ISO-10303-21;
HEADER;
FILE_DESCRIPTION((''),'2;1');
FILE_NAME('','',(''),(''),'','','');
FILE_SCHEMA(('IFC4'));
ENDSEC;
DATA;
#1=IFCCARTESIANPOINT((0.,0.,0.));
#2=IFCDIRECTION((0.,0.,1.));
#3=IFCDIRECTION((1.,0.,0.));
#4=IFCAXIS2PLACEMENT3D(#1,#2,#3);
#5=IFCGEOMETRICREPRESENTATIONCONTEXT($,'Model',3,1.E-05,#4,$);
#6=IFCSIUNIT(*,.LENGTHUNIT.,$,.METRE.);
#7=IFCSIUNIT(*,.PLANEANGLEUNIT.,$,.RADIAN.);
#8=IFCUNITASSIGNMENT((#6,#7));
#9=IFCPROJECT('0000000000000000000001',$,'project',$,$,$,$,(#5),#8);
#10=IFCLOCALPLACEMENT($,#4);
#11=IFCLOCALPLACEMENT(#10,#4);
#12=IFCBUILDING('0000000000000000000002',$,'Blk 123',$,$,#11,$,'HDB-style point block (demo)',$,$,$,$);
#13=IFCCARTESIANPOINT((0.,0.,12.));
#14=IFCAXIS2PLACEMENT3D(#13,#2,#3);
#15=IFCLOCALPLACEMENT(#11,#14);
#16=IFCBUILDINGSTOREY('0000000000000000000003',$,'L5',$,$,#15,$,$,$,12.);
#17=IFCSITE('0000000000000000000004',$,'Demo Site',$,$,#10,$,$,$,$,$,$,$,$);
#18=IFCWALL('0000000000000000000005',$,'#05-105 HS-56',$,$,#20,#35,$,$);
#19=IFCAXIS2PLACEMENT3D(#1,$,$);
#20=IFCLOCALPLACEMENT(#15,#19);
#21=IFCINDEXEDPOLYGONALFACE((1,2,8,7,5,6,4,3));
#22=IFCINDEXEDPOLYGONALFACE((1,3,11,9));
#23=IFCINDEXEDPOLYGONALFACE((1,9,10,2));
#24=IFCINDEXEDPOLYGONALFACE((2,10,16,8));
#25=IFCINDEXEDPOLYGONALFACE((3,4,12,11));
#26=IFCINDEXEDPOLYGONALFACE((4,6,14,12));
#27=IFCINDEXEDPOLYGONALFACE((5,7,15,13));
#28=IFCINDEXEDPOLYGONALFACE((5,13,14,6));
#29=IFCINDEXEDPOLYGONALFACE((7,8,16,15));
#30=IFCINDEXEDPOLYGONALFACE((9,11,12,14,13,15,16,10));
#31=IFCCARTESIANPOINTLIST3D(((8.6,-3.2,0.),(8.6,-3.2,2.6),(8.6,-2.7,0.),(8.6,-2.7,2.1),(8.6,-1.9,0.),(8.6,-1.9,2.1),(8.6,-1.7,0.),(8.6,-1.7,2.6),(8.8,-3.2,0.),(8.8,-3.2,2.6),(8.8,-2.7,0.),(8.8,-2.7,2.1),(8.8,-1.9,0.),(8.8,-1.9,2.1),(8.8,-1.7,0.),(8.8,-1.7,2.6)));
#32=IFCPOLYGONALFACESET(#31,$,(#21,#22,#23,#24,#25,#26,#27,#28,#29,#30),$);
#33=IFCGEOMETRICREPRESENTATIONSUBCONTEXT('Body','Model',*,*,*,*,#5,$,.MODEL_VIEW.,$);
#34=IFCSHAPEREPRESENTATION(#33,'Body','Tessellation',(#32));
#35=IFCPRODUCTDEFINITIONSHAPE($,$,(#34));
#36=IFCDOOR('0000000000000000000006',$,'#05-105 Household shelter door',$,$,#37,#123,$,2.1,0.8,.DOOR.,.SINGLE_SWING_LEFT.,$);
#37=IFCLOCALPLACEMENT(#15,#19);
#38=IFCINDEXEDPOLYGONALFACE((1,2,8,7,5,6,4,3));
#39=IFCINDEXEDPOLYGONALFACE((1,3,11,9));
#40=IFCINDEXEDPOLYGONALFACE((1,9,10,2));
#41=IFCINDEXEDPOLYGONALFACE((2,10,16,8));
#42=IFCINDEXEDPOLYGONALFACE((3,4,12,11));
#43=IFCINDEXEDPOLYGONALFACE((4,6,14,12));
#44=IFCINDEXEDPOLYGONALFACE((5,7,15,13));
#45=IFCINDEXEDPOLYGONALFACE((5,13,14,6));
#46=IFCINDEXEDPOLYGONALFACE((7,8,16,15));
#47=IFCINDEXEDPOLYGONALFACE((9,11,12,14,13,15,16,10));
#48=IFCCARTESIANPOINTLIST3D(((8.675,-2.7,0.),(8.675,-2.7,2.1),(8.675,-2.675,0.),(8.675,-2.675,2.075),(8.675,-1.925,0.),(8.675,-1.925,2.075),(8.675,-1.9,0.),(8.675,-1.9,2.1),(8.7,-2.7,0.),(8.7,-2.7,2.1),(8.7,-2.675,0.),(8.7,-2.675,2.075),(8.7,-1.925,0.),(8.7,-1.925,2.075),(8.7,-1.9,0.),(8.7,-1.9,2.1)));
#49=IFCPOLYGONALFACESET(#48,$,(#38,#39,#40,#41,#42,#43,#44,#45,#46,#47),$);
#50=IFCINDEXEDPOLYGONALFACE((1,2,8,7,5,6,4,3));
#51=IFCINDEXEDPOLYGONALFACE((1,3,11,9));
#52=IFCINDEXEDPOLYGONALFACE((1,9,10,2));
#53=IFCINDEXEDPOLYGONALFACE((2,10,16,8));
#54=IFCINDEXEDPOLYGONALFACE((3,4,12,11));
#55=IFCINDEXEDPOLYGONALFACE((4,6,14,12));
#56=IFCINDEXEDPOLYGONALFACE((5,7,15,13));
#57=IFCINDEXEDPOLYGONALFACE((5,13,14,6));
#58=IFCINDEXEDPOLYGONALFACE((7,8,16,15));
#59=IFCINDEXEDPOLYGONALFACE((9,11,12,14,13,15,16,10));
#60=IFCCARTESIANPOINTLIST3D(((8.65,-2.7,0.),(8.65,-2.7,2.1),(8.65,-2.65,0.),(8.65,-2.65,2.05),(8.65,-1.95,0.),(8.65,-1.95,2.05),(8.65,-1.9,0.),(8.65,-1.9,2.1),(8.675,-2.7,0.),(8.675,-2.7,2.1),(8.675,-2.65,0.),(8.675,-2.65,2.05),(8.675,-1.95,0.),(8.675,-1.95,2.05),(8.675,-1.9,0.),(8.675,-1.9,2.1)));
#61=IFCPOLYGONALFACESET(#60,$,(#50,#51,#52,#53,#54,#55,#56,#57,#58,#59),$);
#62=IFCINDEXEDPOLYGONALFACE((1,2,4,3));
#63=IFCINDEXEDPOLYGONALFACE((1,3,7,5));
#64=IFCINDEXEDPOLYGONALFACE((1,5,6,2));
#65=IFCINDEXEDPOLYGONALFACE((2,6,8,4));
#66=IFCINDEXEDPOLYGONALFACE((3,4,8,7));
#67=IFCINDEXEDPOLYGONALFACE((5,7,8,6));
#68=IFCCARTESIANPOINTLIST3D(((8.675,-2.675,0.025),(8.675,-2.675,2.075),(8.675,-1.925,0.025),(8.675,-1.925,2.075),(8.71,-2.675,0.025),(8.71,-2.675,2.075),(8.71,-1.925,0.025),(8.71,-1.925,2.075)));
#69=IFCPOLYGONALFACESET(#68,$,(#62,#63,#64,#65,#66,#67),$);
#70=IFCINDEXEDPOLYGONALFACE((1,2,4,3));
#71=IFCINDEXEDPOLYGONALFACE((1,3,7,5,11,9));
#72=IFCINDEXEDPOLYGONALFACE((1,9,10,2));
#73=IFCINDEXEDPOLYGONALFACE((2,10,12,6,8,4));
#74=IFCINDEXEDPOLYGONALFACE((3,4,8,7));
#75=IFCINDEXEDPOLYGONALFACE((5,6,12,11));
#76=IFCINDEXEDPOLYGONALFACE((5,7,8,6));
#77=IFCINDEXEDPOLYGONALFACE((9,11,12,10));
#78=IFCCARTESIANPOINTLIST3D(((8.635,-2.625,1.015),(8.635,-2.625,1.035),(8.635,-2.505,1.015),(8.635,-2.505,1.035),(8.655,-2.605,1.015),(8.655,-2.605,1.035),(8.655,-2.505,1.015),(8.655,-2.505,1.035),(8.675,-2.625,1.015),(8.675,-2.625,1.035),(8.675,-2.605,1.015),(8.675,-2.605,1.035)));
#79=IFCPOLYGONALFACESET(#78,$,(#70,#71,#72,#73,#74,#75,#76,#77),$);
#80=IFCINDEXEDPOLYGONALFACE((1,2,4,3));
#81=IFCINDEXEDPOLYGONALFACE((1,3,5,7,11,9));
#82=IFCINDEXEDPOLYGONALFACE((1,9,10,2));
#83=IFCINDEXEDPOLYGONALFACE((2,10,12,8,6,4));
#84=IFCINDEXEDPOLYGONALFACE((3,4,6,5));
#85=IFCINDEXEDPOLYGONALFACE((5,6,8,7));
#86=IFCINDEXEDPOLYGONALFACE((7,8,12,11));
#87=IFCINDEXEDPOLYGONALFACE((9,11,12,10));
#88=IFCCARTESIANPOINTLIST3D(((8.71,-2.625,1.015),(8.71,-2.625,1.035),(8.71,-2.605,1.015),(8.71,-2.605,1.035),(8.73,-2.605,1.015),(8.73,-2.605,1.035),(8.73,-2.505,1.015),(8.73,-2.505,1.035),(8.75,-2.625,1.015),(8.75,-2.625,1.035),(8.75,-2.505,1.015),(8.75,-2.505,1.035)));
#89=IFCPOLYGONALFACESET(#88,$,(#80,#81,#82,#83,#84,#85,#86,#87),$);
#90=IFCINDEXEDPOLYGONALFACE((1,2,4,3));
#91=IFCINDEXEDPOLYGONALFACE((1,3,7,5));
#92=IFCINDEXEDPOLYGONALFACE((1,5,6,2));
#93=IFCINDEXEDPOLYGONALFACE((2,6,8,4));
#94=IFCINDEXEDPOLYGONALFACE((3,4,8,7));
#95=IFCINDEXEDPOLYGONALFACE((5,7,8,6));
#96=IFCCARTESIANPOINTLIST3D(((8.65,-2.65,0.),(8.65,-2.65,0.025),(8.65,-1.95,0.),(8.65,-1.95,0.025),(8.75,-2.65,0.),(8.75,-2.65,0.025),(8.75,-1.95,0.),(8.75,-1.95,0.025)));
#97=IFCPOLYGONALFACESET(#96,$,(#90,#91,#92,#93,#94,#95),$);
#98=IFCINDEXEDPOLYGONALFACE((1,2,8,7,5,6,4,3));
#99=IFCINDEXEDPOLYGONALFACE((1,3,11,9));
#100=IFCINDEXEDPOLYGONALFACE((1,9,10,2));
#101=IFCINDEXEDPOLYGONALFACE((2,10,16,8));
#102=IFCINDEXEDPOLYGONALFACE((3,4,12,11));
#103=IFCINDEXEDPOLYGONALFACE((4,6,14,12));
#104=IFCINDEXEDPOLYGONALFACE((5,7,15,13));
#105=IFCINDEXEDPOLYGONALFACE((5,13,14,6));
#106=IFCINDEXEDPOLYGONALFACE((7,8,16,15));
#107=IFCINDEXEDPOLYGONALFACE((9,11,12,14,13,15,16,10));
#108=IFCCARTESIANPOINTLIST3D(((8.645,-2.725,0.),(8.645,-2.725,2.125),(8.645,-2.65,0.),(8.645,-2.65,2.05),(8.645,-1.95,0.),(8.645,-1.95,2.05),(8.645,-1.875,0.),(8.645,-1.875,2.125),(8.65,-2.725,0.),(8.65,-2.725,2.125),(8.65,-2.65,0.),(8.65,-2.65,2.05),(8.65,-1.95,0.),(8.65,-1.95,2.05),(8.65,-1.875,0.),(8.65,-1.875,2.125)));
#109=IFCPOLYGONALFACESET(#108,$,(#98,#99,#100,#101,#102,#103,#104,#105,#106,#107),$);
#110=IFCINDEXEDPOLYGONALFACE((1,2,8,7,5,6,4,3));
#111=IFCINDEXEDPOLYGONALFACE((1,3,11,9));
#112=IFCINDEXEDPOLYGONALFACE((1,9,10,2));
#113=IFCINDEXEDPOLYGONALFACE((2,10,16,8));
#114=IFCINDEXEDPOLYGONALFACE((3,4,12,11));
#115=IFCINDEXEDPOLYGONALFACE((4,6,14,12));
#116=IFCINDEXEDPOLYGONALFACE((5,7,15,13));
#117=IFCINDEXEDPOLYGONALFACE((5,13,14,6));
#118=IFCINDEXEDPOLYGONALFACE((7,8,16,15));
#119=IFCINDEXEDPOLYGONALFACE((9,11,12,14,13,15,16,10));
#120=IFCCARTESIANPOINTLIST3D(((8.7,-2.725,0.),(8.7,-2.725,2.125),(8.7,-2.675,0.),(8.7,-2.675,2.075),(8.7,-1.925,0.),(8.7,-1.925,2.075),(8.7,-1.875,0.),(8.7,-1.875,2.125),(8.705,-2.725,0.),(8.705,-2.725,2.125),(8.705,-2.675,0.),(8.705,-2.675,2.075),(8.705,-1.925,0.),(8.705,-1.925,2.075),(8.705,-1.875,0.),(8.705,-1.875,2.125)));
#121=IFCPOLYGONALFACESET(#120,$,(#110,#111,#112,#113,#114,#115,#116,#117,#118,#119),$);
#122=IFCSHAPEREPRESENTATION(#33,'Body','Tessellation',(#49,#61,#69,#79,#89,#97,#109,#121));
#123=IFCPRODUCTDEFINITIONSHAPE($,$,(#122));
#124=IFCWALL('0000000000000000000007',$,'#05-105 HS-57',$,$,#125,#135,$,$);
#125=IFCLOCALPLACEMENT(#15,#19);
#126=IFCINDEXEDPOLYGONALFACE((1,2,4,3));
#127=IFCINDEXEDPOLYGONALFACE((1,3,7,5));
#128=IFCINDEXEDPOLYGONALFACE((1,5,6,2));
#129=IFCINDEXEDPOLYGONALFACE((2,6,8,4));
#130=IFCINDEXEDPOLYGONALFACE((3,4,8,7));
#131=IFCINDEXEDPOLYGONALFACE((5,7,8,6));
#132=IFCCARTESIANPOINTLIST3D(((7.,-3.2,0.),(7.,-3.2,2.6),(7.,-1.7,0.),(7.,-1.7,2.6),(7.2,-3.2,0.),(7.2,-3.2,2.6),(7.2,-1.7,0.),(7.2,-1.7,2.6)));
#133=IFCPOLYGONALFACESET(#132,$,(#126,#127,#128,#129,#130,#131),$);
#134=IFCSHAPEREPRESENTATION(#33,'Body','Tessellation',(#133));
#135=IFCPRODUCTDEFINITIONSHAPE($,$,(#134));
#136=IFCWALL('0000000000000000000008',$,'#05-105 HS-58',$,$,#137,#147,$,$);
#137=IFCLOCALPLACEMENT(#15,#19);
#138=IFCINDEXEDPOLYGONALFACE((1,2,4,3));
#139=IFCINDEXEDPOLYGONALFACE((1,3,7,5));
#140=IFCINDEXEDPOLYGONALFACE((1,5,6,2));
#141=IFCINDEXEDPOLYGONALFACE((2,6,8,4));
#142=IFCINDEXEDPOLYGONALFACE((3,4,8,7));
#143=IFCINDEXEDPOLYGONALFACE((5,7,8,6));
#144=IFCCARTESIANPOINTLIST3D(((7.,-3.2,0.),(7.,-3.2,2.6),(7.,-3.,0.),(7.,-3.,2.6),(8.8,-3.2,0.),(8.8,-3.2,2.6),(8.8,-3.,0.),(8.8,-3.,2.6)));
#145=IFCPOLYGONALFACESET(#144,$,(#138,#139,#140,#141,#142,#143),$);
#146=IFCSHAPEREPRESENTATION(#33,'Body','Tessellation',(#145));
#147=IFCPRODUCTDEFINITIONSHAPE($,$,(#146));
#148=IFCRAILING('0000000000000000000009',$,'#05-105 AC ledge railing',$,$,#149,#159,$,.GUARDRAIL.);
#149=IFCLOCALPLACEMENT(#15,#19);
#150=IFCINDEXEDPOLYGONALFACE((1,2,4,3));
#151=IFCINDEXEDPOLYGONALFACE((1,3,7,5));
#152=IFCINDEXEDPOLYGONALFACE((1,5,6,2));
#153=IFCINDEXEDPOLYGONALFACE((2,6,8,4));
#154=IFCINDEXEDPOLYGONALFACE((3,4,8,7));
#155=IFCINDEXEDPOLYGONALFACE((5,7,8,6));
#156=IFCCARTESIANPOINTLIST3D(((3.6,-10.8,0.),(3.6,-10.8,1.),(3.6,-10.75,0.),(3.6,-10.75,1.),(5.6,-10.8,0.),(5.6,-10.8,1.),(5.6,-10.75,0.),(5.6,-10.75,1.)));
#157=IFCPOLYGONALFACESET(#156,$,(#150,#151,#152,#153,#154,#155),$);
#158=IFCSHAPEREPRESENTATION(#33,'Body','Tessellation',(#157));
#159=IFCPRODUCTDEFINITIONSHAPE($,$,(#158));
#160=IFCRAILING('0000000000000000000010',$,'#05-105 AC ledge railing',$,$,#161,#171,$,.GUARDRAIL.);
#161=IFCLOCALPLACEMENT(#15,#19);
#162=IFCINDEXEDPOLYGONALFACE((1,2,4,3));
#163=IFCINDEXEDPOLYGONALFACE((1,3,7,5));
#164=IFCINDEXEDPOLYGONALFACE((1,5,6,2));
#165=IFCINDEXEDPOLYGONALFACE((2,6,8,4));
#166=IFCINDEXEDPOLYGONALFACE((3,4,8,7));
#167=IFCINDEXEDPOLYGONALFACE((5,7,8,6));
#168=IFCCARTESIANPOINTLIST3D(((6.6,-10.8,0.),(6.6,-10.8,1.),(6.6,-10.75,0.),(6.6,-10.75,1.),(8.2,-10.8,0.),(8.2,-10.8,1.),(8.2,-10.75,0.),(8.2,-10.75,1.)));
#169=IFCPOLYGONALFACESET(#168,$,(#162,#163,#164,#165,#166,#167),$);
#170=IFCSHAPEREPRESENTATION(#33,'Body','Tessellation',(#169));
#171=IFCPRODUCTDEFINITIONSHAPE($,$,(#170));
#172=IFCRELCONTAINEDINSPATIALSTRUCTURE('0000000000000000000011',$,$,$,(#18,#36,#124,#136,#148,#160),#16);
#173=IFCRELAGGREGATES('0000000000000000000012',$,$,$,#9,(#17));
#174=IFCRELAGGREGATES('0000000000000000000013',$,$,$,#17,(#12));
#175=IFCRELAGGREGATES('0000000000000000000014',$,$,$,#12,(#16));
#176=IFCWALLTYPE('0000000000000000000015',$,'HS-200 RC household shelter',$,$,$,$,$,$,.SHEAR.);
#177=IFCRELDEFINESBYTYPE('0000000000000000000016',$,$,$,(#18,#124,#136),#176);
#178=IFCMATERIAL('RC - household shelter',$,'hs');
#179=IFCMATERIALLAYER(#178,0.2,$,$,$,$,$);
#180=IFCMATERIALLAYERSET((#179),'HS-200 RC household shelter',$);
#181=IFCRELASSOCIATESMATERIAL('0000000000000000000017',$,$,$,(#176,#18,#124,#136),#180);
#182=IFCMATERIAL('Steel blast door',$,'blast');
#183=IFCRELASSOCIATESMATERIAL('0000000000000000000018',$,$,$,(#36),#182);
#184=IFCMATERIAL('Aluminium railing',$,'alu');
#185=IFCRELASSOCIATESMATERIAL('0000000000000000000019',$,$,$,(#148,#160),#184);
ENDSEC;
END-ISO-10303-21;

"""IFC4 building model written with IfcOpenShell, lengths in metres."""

from ifc_helpers import new_model, si_unit, frame, origin, origin_with_axes, place, context, subcontext, project, spatial, polyline, line, indexed_curve, outline, extrude, material, layer, layer_set, layer_usage, type_object, element, fill, save


model = new_model("IFC4")

# Units and contexts
model_context = context("Model", 3, precision=1e-05, world=origin_with_axes())
body_context = subcontext(model_context, "Body", "Model", "MODEL_VIEW")
ifc_project = project(units=[si_unit("LENGTHUNIT", "METRE"), si_unit("PLANEANGLEUNIT", "RADIAN")], contexts=[model_context])

# Site, building, storey
site_placement = place(None, origin_with_axes())
site = spatial("IfcSite", under=ifc_project, at=site_placement, Name="Demo Site")
building_placement = place(site_placement, origin_with_axes())
building = spatial("IfcBuilding", under=site, at=building_placement, Name="Blk 123", LongName="HDB-style point block (demo)")
storey_placement = place(building_placement, frame((0.0, 0.0, 12.0), z_axis=(0.0, 0.0, 1.0), x_axis=(1.0, 0.0, 0.0)))
storey = spatial("IfcBuildingStorey", under=building, at=storey_placement, Name="L5", Elevation=12.0)

# Wall, opening, door
ifc_material_1 = material(Name="RC - household shelter", Category="hs")
ifc_layer_1 = layer(ifc_material_1, 0.2)
ifc_layer_set_1 = layer_set([ifc_layer_1], Name="HS-200 RC household shelter")
ifc_layer_usage_1 = layer_usage(ifc_layer_set_1, "AXIS2", "POSITIVE", -0.1)
wall_type_1 = type_object("IfcWallType", Name="HS-200 RC household shelter", PredefinedType="SHEAR", material=ifc_layer_set_1)
wall_1_placement = place(storey_placement, frame((8.7, -1.7, 0.0), z_axis=(0.0, 0.0, 1.0), x_axis=(0.0, -1.0, 0.0)))
wall_1 = element("IfcWall", 1, at=wall_1_placement, inside=storey, type_object=wall_type_1, material=ifc_layer_usage_1, Name="#05-105 HS-56", context=body_context, shape_type="SweptSolid", body=[
    extrude(outline(indexed_curve([(0.0, 0.0), (0.0, 0.2), (1.5, 0.2), (1.5, 0.0), (0.0, 0.0)], self_intersect=False)), frame((0.0, -0.1, 0.0), z_axis=(0.0, 0.0, 1.0), x_axis=(1.0, 0.0, 0.0)), (0.0, 0.0, 1.0), 2.6),
])
opening_1_placement = place(wall_1_placement, frame((0.2, -0.2, 0.0), z_axis=(0.0, 0.0, 1.0), x_axis=(1.0, 0.0, 0.0)))
opening_1 = element("IfcOpeningElement", 2, at=opening_1_placement, cuts=wall_1, context=body_context, shape_type="SweptSolid", body=[
    extrude(outline(indexed_curve([(0.0, 0.0), (0.0, 0.4), (0.8, 0.4), (0.8, 0.0), (0.0, 0.0)], self_intersect=False)), origin_with_axes(), (0.0, 0.0, 1.0), 2.1),
])
ifc_material_2 = material(Name="Steel blast door", Category="blast")
door_1_placement = place(opening_1_placement, frame((0.0, 0.15, 0.0), z_axis=(0.0, 0.0, 1.0), x_axis=(1.0, 0.0, 0.0)))
door_1 = element("IfcDoor", 3, at=door_1_placement, inside=storey, material=ifc_material_2, Name="#05-105 Household shelter door", OperationType="SINGLE_SWING_LEFT", OverallHeight=2.1, OverallWidth=0.8, PredefinedType="DOOR", context=body_context, shape_type="SweptSolid", body=[
    extrude(outline(indexed_curve([(0.0, 0.0), (0.0, 2.1), (0.8, 2.1), (0.8, 0.0), (0.775, 0.0), (0.775, 2.075), (0.025, 2.075), (0.025, 0.0)], segments=[line(1, 2, 3, 4, 5, 6, 7, 8, 1)])), frame((0.0, 0.025, 0.0), z_axis=(0.0, -1.0, 0.0), x_axis=(1.0, 0.0, 0.0)), (0.0, 0.0, -1.0), 0.025),
    extrude(outline(indexed_curve([(0.0, 0.0), (0.0, 2.1), (0.8, 2.1), (0.8, 0.0), (0.75, 0.0), (0.75, 2.05), (0.05, 2.05), (0.05, 0.0)], segments=[line(1, 2, 3, 4, 5, 6, 7, 8, 1)])), frame((0.0, 0.0, 0.0), z_axis=(0.0, -1.0, 0.0), x_axis=(1.0, 0.0, 0.0)), (0.0, 0.0, -1.0), 0.025),
    extrude(outline(indexed_curve([(0.0, 0.0), (0.75, 0.0), (0.75, 0.035), (0.0, 0.035)], segments=[line(1, 2, 3, 4, 1)])), frame((0.025, 0.025, 0.025), z_axis=(0.0, 0.0, 1.0), x_axis=(1.0, 0.0, 0.0)), (0.0, 0.0, 1.0), 2.05),
    extrude(outline(indexed_curve([(0.0, 0.0), (0.0, -0.04), (-0.12, -0.04), (-0.12, -0.02), (-0.02, -0.02), (-0.02, 0.0)], segments=[line(1, 2, 3, 4, 5, 6, 1)])), frame((0.725, 0.025, 1.015), z_axis=(0.0, 0.0, 1.0), x_axis=(1.0, 0.0, 0.0)), (0.0, 0.0, 1.0), 0.02),
    extrude(outline(indexed_curve([(0.0, 0.0), (0.0, 0.04), (-0.12, 0.04), (-0.12, 0.02), (-0.02, 0.02), (-0.02, 0.0)], segments=[line(1, 2, 3, 4, 5, 6, 1)])), frame((0.725, 0.06, 1.015), z_axis=(0.0, 0.0, 1.0), x_axis=(1.0, 0.0, 0.0)), (0.0, 0.0, 1.0), 0.02),
    extrude(outline(indexed_curve([(0.0, 0.0), (0.7, 0.0), (0.7, 0.1), (0.0, 0.1)], segments=[line(1, 2, 3, 4, 1)])), frame((0.05, 0.0, 0.0), z_axis=(0.0, 0.0, 1.0), x_axis=(1.0, 0.0, 0.0)), (0.0, 0.0, 1.0), 0.025),
    extrude(outline(indexed_curve([(0.0, 0.0), (0.0, 2.125), (0.85, 2.125), (0.85, 0.0), (0.775, 0.0), (0.775, 2.05), (0.075, 2.05), (0.075, 0.0)], segments=[line(1, 2, 3, 4, 5, 6, 7, 8, 1)])), frame((-0.025, -0.005, 0.0), z_axis=(0.0, -1.0, 0.0), x_axis=(1.0, 0.0, 0.0)), (0.0, 0.0, -1.0), 0.005),
    extrude(outline(indexed_curve([(0.0, 0.0), (0.0, 2.125), (0.85, 2.125), (0.85, 0.0), (0.8, 0.0), (0.8, 2.075), (0.05, 2.075), (0.05, 0.0)], segments=[line(1, 2, 3, 4, 5, 6, 7, 8, 1)])), frame((-0.025, 0.05, 0.0), z_axis=(0.0, -1.0, 0.0), x_axis=(1.0, 0.0, 0.0)), (0.0, 0.0, -1.0), 0.005),
])
fill(opening_1, door_1)

# Walls
wall_2_placement = place(storey_placement, frame((7.1, -1.7, 0.0), z_axis=(0.0, 0.0, 1.0), x_axis=(0.0, -1.0, 0.0)))
element("IfcWall", 4, at=wall_2_placement, inside=storey, type_object=wall_type_1, material=ifc_layer_usage_1, Name="#05-105 HS-57", context=body_context, shape_type="SweptSolid", body=[
    extrude(outline(indexed_curve([(0.0, 0.0), (0.0, 0.2), (1.5, 0.2), (1.5, 0.0), (0.0, 0.0)], self_intersect=False)), frame((0.0, -0.1, 0.0), z_axis=(0.0, 0.0, 1.0), x_axis=(1.0, 0.0, 0.0)), (0.0, 0.0, 1.0), 2.6),
])
wall_3_placement = place(storey_placement, frame((7.0, -3.1, 0.0), z_axis=(0.0, 0.0, 1.0), x_axis=(1.0, 0.0, 0.0)))
element("IfcWall", 5, at=wall_3_placement, inside=storey, type_object=wall_type_1, material=ifc_layer_usage_1, Name="#05-105 HS-58", context=body_context, shape_type="SweptSolid", body=[
    extrude(outline(indexed_curve([(0.0, 0.0), (0.0, 0.2), (1.8, 0.2), (1.8, 0.0), (0.0, 0.0)], self_intersect=False)), frame((0.0, -0.1, 0.0), z_axis=(0.0, 0.0, 1.0), x_axis=(1.0, 0.0, 0.0)), (0.0, 0.0, 1.0), 2.6),
])

# Railings
ifc_material_3 = material(Name="Aluminium railing", Category="alu")
railing_1_placement = place(storey_placement, frame((4.6, -10.775, 0.0), z_axis=(0.0, 0.0, 1.0), x_axis=(1.0, 0.0, 0.0)))
element("IfcRailing", 6, at=railing_1_placement, inside=storey, material=ifc_material_3, Name="#05-105 AC ledge railing", PredefinedType="GUARDRAIL", context=body_context, shape_type="SweptSolid", body=[
    extrude(outline(polyline([(1.0, 0.025), (-1.0, 0.025), (-1.0, -0.025), (1.0, -0.025), (1.0, 0.025)])), origin(), (0.0, 0.0, 1.0), 1.0),
])
railing_2_placement = place(storey_placement, frame((7.4, -10.775, 0.0), z_axis=(0.0, 0.0, 1.0), x_axis=(1.0, 0.0, 0.0)))
element("IfcRailing", 7, at=railing_2_placement, inside=storey, material=ifc_material_3, Name="#05-105 AC ledge railing", PredefinedType="GUARDRAIL", context=body_context, shape_type="SweptSolid", body=[
    extrude(outline(polyline([(0.8, 0.025), (-0.8, 0.025), (-0.8, -0.025), (0.8, -0.025), (0.8, 0.025)])), origin(), (0.0, 0.0, 1.0), 1.0),
])

save(model, "model.ifc")
